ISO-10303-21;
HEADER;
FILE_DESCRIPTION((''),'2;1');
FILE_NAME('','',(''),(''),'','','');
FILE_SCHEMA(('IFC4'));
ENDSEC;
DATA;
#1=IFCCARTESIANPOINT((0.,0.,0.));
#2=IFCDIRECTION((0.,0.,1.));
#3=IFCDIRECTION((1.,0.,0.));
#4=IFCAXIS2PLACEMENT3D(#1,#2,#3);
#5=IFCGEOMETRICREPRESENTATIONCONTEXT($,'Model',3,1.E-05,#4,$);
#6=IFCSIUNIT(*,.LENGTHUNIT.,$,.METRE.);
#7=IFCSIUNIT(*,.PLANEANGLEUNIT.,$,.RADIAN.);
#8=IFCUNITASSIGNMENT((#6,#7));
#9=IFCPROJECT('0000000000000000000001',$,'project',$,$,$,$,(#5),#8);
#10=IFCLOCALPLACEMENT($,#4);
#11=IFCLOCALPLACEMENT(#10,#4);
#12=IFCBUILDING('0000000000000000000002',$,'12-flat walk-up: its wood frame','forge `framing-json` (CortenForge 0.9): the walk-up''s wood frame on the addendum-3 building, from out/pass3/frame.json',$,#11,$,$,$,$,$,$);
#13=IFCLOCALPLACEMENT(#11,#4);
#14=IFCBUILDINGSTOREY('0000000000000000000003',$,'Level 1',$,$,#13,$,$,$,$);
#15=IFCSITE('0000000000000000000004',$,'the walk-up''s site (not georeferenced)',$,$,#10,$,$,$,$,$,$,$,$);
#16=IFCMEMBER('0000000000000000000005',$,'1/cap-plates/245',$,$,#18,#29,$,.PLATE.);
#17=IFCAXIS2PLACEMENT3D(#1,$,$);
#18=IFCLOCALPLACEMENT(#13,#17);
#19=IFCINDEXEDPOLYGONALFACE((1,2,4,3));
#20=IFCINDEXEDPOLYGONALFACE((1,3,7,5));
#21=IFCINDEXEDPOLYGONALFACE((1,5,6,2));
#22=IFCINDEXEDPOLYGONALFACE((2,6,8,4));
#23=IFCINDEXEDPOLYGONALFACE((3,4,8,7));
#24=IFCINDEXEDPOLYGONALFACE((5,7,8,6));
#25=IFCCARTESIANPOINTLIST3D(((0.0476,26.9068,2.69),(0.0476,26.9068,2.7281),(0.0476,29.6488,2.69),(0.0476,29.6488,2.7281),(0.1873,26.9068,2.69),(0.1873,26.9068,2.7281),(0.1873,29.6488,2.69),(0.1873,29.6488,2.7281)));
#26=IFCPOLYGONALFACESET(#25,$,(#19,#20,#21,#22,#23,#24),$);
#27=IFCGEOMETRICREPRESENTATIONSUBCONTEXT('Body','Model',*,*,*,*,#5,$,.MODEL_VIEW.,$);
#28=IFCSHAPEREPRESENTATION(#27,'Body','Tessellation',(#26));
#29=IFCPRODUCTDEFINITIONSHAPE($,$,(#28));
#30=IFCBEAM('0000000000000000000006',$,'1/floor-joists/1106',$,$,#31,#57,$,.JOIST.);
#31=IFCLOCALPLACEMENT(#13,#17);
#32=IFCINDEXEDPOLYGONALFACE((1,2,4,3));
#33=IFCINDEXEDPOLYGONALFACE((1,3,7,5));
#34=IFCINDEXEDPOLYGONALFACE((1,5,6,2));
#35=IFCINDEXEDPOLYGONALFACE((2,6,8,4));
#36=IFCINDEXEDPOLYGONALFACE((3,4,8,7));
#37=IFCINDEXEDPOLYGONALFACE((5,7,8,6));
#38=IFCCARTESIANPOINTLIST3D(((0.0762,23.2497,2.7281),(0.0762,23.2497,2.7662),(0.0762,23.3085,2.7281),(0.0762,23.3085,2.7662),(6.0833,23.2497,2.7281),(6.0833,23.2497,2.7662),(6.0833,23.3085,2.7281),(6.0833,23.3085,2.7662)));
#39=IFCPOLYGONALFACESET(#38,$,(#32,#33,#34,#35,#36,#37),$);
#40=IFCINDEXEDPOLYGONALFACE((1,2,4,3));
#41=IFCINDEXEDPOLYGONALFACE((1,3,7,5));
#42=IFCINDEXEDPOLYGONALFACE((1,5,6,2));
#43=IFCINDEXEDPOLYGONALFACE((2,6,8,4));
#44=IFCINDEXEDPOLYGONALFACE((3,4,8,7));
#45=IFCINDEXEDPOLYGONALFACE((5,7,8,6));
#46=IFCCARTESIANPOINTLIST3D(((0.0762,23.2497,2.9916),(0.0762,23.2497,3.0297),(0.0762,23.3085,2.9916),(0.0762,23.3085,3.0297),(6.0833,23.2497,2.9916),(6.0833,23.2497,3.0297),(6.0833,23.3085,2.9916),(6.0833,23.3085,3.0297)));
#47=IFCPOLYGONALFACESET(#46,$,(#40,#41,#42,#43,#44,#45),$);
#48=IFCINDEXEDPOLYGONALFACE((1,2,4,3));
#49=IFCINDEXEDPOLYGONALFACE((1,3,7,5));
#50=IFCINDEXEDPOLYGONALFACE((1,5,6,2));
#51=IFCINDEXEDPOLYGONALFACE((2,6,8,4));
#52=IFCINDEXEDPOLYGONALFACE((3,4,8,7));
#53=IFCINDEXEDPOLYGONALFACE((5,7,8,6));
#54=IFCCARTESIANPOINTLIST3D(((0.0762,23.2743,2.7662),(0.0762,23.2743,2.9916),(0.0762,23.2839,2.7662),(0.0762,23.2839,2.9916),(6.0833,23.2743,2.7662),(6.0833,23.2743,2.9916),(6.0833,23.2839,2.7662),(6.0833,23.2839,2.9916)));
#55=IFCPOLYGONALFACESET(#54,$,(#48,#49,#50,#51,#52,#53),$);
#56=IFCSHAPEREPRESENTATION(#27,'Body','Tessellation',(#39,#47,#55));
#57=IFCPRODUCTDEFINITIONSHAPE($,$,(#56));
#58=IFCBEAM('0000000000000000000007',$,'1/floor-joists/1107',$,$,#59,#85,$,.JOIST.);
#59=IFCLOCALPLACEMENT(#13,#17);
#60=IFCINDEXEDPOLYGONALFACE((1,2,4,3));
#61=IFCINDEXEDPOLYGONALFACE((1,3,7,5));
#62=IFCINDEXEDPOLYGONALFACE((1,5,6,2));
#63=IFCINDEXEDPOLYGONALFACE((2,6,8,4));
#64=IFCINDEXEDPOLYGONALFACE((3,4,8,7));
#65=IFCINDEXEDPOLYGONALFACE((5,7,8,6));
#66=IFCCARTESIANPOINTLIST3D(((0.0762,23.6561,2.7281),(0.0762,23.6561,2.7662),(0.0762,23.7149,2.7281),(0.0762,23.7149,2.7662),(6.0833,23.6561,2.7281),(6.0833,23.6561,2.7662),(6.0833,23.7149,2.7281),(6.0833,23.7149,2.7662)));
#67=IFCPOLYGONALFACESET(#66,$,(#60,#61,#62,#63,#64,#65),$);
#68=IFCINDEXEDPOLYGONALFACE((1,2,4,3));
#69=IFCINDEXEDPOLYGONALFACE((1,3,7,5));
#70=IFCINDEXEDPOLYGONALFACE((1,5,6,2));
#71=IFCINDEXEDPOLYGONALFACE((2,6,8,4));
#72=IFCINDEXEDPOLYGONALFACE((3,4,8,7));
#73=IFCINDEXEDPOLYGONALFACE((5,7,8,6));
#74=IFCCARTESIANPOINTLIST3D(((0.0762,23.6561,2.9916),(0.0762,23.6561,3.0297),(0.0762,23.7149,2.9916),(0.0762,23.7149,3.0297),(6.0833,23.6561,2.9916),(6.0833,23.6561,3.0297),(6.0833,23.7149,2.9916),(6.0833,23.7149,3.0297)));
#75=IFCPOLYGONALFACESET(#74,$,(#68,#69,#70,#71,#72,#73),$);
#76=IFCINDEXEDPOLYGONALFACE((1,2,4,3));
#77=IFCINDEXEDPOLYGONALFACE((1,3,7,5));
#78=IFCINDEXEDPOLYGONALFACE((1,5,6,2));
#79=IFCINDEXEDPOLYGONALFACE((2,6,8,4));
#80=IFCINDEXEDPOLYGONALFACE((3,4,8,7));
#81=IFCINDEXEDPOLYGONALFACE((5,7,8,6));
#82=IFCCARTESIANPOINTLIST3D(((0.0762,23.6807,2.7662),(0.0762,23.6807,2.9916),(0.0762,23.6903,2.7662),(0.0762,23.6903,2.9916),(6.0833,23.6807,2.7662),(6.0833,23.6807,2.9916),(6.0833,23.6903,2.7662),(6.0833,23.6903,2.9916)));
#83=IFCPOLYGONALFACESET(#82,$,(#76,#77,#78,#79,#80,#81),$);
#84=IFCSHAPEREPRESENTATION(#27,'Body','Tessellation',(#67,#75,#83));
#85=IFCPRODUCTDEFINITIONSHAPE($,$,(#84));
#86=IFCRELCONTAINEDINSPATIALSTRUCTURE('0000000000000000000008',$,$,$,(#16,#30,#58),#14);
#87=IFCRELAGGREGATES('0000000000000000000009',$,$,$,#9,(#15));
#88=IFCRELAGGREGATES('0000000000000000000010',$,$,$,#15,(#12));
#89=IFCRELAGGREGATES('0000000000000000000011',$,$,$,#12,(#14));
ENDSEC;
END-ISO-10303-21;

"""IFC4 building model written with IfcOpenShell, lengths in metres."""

from ifc_helpers import new_model, si_unit, frame, frame_2d, origin, origin_with_axes, place, context, subcontext, project, spatial, rectangle, extrude, element, save


model = new_model("IFC4")

# Units and contexts
model_context = context("Model", 3, precision=1e-05, world=origin_with_axes())
body_context = subcontext(model_context, "Body", "Model", "MODEL_VIEW")
ifc_project = project(units=[si_unit("LENGTHUNIT", "METRE"), si_unit("PLANEANGLEUNIT", "RADIAN")], contexts=[model_context])

# Site, building, storey
site_placement = place(None, origin_with_axes())
site = spatial("IfcSite", under=ifc_project, at=site_placement, Name="the walk-up's site (not georeferenced)")
building_placement = place(site_placement, origin_with_axes())
building = spatial("IfcBuilding", under=site, at=building_placement, Name="12-flat walk-up: its wood frame", Description="forge `framing-json` (CortenForge 0.9): the walk-up's wood frame on the addendum-3 building, from out/pass3/frame.json")
storey_placement = place(building_placement, origin_with_axes())
storey = spatial("IfcBuildingStorey", under=building, at=storey_placement, Name="Level 1")

# Member
member_1_placement = place(storey_placement, frame((0.0476, 26.9068, 2.69), z_axis=(0.0, 0.0, 1.0), x_axis=(1.0, 0.0, 0.0)))
element("IfcMember", 1, at=member_1_placement, inside=storey, Name="1/cap-plates/245", PredefinedType="PLATE", context=body_context, shape_type="SweptSolid", body=[
    extrude(rectangle(XDim=0.1397, YDim=2.742, at=frame_2d((0.0698, 1.371))), origin(), (0.0, 0.0, 1.0), 0.0381),
])

# Beams
beam_1_placement = place(storey_placement, frame((0.0762, 23.2497, 2.7281), z_axis=(0.0, 0.0, 1.0), x_axis=(1.0, 0.0, 0.0)))
element("IfcBeam", 2, at=beam_1_placement, inside=storey, Name="1/floor-joists/1106", PredefinedType="JOIST", context=body_context, shape_type="SweptSolid", body=[
    extrude(rectangle(XDim=6.0071, YDim=0.0587, at=frame_2d((3.0036, 0.0294))), origin(), (0.0, 0.0, 1.0), 0.0381),
    extrude(rectangle(XDim=6.0071, YDim=0.0587, at=frame_2d((3.0036, 0.0294))), frame((0.0, 0.0, 0.2635)), (0.0, 0.0, 1.0), 0.0381),
    extrude(rectangle(XDim=6.0071, YDim=0.0095, at=frame_2d((3.0036, 0.0048))), frame((0.0, 0.0246, 0.0381)), (0.0, 0.0, 1.0), 0.2254),
])
beam_2_placement = place(storey_placement, frame((0.0762, 23.6561, 2.7281), z_axis=(0.0, 0.0, 1.0), x_axis=(1.0, 0.0, 0.0)))
element("IfcBeam", 3, at=beam_2_placement, inside=storey, Name="1/floor-joists/1107", PredefinedType="JOIST", context=body_context, shape_type="SweptSolid", body=[
    extrude(rectangle(XDim=6.0071, YDim=0.0587, at=frame_2d((3.0036, 0.0294))), origin(), (0.0, 0.0, 1.0), 0.0381),
    extrude(rectangle(XDim=6.0071, YDim=0.0587, at=frame_2d((3.0036, 0.0294))), frame((0.0, 0.0, 0.2635)), (0.0, 0.0, 1.0), 0.0381),
    extrude(rectangle(XDim=6.0071, YDim=0.0095, at=frame_2d((3.0036, 0.0048))), frame((0.0, 0.0246, 0.0381)), (0.0, 0.0, 1.0), 0.2254),
])

save(model, "model.ifc")
